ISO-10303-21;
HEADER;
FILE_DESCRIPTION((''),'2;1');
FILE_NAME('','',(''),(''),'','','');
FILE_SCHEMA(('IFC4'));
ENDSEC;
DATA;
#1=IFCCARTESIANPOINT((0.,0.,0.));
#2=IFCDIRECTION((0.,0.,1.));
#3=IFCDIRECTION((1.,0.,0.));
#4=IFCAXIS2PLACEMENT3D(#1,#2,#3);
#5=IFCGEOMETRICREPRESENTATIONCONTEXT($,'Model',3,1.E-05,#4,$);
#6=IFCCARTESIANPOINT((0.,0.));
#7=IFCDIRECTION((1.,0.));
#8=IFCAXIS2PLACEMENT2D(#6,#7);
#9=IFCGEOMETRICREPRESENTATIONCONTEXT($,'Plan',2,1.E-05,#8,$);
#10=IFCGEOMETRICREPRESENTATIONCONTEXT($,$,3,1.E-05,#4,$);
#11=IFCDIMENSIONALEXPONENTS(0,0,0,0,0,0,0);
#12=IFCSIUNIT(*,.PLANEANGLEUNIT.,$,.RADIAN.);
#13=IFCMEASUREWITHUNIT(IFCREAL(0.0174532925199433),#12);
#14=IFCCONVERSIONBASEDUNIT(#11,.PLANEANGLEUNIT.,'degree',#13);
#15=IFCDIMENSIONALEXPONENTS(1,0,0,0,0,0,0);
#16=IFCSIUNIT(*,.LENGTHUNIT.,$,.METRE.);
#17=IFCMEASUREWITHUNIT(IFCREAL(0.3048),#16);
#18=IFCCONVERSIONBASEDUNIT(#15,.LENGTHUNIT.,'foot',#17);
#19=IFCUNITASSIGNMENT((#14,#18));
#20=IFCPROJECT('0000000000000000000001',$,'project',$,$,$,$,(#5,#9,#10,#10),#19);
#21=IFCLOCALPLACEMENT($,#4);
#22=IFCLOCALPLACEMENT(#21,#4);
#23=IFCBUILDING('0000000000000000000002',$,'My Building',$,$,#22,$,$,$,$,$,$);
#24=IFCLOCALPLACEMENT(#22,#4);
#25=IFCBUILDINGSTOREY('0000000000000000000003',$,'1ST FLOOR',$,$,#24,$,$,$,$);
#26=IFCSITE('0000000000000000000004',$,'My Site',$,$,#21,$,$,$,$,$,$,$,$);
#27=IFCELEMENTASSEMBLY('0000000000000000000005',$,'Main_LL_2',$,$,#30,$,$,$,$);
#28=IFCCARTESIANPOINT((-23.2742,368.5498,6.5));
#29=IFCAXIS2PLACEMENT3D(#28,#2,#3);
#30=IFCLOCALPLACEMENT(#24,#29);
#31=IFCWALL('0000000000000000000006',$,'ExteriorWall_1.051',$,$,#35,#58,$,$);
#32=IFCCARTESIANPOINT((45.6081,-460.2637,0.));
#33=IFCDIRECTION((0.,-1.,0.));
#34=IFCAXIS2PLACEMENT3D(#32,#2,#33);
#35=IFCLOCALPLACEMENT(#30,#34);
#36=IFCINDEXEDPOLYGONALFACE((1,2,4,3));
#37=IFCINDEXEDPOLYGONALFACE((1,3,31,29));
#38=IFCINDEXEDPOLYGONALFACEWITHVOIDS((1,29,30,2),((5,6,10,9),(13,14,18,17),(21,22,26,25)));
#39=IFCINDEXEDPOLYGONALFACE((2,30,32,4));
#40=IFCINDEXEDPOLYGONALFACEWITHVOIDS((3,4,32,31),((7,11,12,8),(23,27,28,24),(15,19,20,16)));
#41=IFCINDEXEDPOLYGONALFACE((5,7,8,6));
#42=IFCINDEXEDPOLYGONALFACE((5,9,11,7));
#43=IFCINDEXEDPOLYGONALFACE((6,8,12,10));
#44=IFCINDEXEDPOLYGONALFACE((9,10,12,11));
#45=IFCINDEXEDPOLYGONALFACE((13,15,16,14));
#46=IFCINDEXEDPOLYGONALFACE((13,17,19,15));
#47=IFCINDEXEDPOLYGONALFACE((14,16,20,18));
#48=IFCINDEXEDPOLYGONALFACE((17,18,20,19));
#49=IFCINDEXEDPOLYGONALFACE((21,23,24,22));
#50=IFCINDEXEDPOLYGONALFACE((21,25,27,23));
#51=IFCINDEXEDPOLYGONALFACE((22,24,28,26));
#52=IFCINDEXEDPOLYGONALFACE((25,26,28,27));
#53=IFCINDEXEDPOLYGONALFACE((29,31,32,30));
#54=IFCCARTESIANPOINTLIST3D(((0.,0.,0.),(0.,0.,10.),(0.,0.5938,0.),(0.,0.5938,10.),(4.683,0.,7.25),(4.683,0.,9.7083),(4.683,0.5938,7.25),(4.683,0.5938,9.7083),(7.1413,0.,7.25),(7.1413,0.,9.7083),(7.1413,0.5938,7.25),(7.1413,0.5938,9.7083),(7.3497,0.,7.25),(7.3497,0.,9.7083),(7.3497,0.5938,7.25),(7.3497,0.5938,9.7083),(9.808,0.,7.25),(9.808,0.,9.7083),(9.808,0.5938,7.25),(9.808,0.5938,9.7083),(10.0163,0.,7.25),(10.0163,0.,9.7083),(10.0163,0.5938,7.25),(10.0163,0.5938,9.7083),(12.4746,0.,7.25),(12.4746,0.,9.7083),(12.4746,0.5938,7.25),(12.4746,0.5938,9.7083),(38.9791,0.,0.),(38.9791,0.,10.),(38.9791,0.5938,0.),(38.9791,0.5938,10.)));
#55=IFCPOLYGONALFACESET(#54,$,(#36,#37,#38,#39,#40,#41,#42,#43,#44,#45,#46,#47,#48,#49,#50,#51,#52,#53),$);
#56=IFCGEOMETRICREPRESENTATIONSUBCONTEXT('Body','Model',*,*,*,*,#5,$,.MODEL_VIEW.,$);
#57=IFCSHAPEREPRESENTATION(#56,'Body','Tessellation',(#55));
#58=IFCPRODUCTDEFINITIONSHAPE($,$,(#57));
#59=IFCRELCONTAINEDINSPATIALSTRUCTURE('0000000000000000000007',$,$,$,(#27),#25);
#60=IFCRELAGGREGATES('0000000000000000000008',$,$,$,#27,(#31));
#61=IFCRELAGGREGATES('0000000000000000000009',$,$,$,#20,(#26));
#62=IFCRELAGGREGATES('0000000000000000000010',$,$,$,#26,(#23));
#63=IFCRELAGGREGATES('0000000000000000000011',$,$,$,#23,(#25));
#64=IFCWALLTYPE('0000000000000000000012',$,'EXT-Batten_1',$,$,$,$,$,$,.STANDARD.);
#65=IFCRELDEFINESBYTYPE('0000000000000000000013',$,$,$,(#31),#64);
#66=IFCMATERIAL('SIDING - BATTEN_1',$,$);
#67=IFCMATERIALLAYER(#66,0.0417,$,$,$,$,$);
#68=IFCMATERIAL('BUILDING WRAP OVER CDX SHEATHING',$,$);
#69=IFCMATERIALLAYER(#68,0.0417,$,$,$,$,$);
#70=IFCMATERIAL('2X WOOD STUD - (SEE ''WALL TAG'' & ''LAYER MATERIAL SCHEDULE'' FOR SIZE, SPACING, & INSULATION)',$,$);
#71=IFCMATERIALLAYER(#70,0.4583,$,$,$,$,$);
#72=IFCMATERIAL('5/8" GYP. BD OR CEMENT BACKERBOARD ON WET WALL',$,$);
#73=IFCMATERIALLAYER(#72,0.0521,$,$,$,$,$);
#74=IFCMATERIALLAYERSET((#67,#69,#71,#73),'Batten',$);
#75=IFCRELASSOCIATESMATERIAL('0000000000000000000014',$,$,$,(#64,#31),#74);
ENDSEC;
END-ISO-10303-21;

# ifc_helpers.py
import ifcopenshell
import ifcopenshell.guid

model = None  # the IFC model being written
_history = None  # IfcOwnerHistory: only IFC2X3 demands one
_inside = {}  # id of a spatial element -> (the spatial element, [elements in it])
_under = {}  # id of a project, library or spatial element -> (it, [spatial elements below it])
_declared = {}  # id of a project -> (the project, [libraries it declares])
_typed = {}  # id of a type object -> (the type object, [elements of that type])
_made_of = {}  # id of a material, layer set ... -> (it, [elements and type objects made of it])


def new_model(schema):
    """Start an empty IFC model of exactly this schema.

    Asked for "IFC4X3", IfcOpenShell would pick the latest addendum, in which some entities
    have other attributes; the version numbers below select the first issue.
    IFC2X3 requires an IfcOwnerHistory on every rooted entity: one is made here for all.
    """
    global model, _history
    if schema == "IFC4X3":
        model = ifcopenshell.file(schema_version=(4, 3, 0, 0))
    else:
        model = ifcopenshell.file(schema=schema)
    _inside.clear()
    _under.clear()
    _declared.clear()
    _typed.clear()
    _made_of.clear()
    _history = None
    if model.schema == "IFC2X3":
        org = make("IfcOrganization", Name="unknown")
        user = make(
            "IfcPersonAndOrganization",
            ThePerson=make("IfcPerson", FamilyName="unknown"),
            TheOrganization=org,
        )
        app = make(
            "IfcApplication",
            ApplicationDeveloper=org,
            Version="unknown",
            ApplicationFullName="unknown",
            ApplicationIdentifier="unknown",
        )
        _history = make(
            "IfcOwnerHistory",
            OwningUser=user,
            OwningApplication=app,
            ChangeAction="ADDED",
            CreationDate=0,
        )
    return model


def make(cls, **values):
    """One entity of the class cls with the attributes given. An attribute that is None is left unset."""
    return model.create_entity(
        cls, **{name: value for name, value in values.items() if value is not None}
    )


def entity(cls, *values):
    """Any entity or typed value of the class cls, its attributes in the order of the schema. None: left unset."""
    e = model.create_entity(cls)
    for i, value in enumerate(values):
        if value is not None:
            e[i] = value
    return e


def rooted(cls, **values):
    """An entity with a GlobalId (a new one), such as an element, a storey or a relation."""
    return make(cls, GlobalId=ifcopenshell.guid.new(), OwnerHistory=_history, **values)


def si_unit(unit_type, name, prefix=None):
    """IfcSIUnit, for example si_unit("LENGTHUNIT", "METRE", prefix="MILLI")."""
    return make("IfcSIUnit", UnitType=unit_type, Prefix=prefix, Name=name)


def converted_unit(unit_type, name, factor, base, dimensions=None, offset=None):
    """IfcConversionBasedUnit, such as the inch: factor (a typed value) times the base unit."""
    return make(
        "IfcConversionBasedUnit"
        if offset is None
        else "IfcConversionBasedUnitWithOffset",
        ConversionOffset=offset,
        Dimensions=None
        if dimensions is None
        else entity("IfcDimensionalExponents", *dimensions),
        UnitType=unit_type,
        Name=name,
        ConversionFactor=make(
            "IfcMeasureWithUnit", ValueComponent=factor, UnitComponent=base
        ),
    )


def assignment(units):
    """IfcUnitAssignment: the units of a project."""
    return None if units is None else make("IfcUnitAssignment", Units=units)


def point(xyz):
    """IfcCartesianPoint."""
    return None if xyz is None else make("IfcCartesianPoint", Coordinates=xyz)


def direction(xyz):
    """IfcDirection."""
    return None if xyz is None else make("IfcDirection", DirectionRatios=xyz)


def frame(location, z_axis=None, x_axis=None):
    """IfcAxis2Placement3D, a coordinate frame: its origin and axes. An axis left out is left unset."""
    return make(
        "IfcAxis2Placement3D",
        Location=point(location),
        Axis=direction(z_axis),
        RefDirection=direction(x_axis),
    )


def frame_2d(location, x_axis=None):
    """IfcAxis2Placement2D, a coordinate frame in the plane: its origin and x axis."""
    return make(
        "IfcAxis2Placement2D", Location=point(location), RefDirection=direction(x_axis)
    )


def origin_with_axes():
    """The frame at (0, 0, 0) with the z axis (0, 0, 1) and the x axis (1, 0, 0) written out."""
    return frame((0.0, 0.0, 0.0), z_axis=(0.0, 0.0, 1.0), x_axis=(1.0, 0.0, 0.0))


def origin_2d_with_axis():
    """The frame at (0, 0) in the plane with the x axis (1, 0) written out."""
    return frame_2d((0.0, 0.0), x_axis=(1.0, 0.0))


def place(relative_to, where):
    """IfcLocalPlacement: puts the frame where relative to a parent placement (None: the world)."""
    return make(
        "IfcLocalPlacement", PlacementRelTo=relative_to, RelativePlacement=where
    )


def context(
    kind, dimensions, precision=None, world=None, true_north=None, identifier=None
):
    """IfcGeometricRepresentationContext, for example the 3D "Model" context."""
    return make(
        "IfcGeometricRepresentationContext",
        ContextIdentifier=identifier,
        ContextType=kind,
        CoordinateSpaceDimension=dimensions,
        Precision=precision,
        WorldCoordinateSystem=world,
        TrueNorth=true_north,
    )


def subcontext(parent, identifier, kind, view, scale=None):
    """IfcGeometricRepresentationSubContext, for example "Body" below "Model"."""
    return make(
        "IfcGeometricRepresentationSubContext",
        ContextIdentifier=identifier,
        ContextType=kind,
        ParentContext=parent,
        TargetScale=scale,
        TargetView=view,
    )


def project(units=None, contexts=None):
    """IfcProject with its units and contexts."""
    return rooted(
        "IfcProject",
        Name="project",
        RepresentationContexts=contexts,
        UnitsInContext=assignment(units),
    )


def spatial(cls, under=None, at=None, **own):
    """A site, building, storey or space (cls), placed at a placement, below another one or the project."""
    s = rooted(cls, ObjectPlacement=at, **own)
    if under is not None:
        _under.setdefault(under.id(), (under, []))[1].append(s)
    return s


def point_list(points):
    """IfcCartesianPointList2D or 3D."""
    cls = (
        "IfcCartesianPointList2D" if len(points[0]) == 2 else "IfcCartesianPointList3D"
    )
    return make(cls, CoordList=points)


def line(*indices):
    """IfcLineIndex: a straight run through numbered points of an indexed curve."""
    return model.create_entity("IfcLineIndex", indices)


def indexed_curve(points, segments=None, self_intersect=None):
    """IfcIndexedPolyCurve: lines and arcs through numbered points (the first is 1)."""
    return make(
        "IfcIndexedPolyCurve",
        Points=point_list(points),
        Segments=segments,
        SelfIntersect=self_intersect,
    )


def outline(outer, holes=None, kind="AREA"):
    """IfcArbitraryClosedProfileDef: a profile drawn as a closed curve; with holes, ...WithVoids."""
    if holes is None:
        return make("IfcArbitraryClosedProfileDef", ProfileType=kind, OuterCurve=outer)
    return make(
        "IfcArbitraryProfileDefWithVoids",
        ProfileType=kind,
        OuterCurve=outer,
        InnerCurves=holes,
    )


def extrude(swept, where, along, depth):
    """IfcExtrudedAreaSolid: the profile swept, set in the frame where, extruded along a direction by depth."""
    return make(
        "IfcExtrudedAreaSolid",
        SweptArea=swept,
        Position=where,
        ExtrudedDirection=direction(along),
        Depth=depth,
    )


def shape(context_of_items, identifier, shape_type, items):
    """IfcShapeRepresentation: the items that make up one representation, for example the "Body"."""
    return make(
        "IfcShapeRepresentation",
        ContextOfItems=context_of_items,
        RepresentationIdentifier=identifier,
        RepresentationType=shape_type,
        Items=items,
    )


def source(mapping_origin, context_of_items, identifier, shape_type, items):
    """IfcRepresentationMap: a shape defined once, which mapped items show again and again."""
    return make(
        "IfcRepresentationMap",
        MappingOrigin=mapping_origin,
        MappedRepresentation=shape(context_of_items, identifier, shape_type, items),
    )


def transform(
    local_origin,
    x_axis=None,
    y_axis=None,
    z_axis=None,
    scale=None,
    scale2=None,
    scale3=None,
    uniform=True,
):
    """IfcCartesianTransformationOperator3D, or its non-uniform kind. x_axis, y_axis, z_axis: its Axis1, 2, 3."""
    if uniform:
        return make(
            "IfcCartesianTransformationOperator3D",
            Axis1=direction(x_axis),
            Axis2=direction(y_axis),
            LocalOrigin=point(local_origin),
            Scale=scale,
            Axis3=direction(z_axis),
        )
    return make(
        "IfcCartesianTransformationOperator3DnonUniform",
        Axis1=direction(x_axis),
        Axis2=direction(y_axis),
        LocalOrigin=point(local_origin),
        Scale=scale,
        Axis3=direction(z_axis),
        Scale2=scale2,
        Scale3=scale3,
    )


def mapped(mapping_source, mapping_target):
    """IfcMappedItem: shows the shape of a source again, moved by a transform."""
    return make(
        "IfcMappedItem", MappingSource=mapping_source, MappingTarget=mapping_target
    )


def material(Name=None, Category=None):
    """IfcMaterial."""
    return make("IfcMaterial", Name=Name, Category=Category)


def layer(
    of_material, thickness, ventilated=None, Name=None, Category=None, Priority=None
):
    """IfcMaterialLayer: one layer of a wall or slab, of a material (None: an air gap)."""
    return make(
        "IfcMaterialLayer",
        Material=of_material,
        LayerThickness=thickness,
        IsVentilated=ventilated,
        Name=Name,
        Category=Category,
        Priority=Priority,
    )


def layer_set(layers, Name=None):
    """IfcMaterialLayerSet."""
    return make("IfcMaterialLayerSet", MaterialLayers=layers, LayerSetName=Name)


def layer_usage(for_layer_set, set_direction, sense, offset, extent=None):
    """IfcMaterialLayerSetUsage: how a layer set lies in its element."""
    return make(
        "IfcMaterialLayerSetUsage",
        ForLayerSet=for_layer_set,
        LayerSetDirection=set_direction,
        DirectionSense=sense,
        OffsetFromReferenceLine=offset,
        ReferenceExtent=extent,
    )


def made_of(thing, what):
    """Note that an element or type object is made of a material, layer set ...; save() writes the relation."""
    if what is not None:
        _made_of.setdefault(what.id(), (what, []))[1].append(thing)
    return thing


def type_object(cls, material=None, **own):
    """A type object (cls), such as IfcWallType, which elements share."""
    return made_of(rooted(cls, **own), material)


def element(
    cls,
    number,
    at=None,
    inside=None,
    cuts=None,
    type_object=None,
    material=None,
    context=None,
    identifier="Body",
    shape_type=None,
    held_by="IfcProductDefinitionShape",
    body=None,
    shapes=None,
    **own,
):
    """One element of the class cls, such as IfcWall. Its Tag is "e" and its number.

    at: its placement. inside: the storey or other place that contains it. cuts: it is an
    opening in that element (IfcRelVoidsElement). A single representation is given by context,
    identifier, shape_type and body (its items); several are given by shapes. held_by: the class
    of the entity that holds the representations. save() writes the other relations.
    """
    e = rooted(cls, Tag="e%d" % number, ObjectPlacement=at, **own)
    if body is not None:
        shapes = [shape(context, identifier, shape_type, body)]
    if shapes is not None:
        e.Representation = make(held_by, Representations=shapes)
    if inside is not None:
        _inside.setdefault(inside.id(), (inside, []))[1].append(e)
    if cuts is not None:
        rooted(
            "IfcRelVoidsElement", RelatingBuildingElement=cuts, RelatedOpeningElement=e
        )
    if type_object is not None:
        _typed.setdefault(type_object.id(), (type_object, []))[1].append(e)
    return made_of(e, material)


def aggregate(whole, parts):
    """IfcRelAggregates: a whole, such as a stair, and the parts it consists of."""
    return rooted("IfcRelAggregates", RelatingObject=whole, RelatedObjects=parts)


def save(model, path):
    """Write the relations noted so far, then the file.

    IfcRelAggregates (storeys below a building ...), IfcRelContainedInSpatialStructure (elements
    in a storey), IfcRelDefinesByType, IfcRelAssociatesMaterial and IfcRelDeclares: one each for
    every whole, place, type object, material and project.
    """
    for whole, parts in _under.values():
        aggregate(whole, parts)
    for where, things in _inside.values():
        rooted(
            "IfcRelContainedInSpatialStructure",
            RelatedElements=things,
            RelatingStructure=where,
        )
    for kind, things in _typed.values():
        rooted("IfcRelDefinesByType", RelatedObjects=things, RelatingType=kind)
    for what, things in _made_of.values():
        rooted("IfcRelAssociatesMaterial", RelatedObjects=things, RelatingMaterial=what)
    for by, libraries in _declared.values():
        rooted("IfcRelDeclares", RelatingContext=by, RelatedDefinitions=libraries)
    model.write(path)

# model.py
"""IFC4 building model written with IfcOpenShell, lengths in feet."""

from ifc_helpers import new_model, entity, si_unit, converted_unit, frame, origin_with_axes, origin_2d_with_axis, place, context, subcontext, project, spatial, line, indexed_curve, outline, extrude, source, transform, mapped, material, layer, layer_set, layer_usage, type_object, element, aggregate, save


model = new_model("IFC4")

# Units and contexts
model_context = context("Model", 3, precision=1e-05, world=origin_with_axes())
plan_context = context("Plan", 2, precision=1e-05, world=origin_2d_with_axis())
context_of_model = context(None, 3, precision=1e-05, world=origin_with_axes())
body_context = subcontext(model_context, "Body", "Model", "MODEL_VIEW")
ifc_project = project(units=[converted_unit("PLANEANGLEUNIT", "degree", entity("IfcReal", 0.0174532925199433), si_unit("PLANEANGLEUNIT", "RADIAN"), dimensions=[0, 0, 0, 0, 0, 0, 0]), converted_unit("LENGTHUNIT", "foot", entity("IfcReal", 0.3048), si_unit("LENGTHUNIT", "METRE"), dimensions=[1, 0, 0, 0, 0, 0, 0])], contexts=[model_context, plan_context, context_of_model, context_of_model])

# Site, building, storey
site_placement = place(None, origin_with_axes())
site = spatial("IfcSite", under=ifc_project, at=site_placement, Name="My Site")
building_placement = place(site_placement, origin_with_axes())
building = spatial("IfcBuilding", under=site, at=building_placement, Name="My Building")
storey_placement = place(building_placement, origin_with_axes())
storey = spatial("IfcBuildingStorey", under=building, at=storey_placement, Name="1ST FLOOR")

# Element assembly, wall, openings
assembly_placement = place(storey_placement, frame((-23.2742, 368.5498, 6.5), z_axis=(0.0, 0.0, 1.0), x_axis=(1.0, 0.0, 0.0)))
assembly = element("IfcElementAssembly", 1, at=assembly_placement, inside=storey, Name="Main_LL_2")
ifc_material_1 = material(Name="SIDING - BATTEN_1")
ifc_layer_1 = layer(ifc_material_1, 0.0417)
ifc_material_2 = material(Name="BUILDING WRAP OVER CDX SHEATHING")
ifc_layer_2 = layer(ifc_material_2, 0.0417)
ifc_material_3 = material(Name="2X WOOD STUD - (SEE 'WALL TAG' & 'LAYER MATERIAL SCHEDULE' FOR SIZE, SPACING, & INSULATION)")
ifc_layer_3 = layer(ifc_material_3, 0.4583)
ifc_material_4 = material(Name="5/8\" GYP. BD OR CEMENT BACKERBOARD ON WET WALL")
ifc_layer_4 = layer(ifc_material_4, 0.0521)
ifc_layer_set_1 = layer_set([ifc_layer_1, ifc_layer_2, ifc_layer_3, ifc_layer_4], Name="Batten")
ifc_layer_usage_1 = layer_usage(ifc_layer_set_1, "AXIS2", "POSITIVE", 0.0)
wall_type_1 = type_object("IfcWallType", Name="EXT-Batten_1", PredefinedType="STANDARD", material=ifc_layer_set_1)
wall_1_placement = place(assembly_placement, frame((45.6081, -460.2637, 0.0), z_axis=(0.0, 0.0, 1.0), x_axis=(0.0, -1.0, 0.0)))
wall_1 = element("IfcWall", 2, at=wall_1_placement, type_object=wall_type_1, material=ifc_layer_usage_1, Name="ExteriorWall_1.051", context=body_context, shape_type="SweptSolid", body=[
    extrude(outline(indexed_curve([(0.0, 0.0), (0.0, 0.5938), (38.9791, 0.5938), (38.9791, 0.0), (0.0, 0.0)], self_intersect=False)), origin_with_axes(), (0.0, 0.0, 1.0), 10.0),
])
shared_shape_1 = source(origin_with_axes(), body_context, "Body", "SweptSolid", [
    extrude(outline(indexed_curve([(0.0, 0.0), (2.4583, 0.0), (2.4583, 2.4583), (0.0, 2.4583)], segments=[line(1, 2, 3, 4, 1)])), frame((0.0, -1.9685, 0.0), z_axis=(0.0, -1.0, 0.0), x_axis=(1.0, 0.0, 0.0)), (0.0, 0.0, -1.0), 3.937),
])
opening_1_placement = place(wall_1_placement, frame((4.683, 0.0, 7.25), z_axis=(0.0, 0.0, 1.0), x_axis=(1.0, 0.0, 0.0)))
element("IfcOpeningElement", 3, at=opening_1_placement, cuts=wall_1, PredefinedType="OPENING", context=body_context, shape_type="MappedRepresentation", body=[
    mapped(shared_shape_1, transform((0.0, 0.0, 0.0), x_axis=(1.0, 0.0, 0.0), y_axis=(0.0, 1.0, 0.0), z_axis=(0.0, 0.0, 1.0), scale=1.0)),
])
opening_2_placement = place(wall_1_placement, frame((7.3497, 0.0, 7.25), z_axis=(0.0, 0.0, 1.0), x_axis=(1.0, 0.0, 0.0)))
element("IfcOpeningElement", 4, at=opening_2_placement, cuts=wall_1, PredefinedType="OPENING", context=body_context, shape_type="MappedRepresentation", body=[
    mapped(shared_shape_1, transform((0.0, 0.0, 0.0), x_axis=(1.0, 0.0, 0.0), y_axis=(0.0, 1.0, 0.0), z_axis=(0.0, 0.0, 1.0), scale=1.0)),
])
opening_3_placement = place(wall_1_placement, frame((10.0163, 0.0, 7.25), z_axis=(0.0, 0.0, 1.0), x_axis=(1.0, 0.0, 0.0)))
element("IfcOpeningElement", 5, at=opening_3_placement, cuts=wall_1, PredefinedType="OPENING", context=body_context, shape_type="MappedRepresentation", body=[
    mapped(shared_shape_1, transform((0.0, 0.0, 0.0), x_axis=(1.0, 0.0, 0.0), y_axis=(0.0, 1.0, 0.0), z_axis=(0.0, 0.0, 1.0), scale=1.0)),
])
aggregate(assembly, [wall_1])

save(model, "model.ifc")
